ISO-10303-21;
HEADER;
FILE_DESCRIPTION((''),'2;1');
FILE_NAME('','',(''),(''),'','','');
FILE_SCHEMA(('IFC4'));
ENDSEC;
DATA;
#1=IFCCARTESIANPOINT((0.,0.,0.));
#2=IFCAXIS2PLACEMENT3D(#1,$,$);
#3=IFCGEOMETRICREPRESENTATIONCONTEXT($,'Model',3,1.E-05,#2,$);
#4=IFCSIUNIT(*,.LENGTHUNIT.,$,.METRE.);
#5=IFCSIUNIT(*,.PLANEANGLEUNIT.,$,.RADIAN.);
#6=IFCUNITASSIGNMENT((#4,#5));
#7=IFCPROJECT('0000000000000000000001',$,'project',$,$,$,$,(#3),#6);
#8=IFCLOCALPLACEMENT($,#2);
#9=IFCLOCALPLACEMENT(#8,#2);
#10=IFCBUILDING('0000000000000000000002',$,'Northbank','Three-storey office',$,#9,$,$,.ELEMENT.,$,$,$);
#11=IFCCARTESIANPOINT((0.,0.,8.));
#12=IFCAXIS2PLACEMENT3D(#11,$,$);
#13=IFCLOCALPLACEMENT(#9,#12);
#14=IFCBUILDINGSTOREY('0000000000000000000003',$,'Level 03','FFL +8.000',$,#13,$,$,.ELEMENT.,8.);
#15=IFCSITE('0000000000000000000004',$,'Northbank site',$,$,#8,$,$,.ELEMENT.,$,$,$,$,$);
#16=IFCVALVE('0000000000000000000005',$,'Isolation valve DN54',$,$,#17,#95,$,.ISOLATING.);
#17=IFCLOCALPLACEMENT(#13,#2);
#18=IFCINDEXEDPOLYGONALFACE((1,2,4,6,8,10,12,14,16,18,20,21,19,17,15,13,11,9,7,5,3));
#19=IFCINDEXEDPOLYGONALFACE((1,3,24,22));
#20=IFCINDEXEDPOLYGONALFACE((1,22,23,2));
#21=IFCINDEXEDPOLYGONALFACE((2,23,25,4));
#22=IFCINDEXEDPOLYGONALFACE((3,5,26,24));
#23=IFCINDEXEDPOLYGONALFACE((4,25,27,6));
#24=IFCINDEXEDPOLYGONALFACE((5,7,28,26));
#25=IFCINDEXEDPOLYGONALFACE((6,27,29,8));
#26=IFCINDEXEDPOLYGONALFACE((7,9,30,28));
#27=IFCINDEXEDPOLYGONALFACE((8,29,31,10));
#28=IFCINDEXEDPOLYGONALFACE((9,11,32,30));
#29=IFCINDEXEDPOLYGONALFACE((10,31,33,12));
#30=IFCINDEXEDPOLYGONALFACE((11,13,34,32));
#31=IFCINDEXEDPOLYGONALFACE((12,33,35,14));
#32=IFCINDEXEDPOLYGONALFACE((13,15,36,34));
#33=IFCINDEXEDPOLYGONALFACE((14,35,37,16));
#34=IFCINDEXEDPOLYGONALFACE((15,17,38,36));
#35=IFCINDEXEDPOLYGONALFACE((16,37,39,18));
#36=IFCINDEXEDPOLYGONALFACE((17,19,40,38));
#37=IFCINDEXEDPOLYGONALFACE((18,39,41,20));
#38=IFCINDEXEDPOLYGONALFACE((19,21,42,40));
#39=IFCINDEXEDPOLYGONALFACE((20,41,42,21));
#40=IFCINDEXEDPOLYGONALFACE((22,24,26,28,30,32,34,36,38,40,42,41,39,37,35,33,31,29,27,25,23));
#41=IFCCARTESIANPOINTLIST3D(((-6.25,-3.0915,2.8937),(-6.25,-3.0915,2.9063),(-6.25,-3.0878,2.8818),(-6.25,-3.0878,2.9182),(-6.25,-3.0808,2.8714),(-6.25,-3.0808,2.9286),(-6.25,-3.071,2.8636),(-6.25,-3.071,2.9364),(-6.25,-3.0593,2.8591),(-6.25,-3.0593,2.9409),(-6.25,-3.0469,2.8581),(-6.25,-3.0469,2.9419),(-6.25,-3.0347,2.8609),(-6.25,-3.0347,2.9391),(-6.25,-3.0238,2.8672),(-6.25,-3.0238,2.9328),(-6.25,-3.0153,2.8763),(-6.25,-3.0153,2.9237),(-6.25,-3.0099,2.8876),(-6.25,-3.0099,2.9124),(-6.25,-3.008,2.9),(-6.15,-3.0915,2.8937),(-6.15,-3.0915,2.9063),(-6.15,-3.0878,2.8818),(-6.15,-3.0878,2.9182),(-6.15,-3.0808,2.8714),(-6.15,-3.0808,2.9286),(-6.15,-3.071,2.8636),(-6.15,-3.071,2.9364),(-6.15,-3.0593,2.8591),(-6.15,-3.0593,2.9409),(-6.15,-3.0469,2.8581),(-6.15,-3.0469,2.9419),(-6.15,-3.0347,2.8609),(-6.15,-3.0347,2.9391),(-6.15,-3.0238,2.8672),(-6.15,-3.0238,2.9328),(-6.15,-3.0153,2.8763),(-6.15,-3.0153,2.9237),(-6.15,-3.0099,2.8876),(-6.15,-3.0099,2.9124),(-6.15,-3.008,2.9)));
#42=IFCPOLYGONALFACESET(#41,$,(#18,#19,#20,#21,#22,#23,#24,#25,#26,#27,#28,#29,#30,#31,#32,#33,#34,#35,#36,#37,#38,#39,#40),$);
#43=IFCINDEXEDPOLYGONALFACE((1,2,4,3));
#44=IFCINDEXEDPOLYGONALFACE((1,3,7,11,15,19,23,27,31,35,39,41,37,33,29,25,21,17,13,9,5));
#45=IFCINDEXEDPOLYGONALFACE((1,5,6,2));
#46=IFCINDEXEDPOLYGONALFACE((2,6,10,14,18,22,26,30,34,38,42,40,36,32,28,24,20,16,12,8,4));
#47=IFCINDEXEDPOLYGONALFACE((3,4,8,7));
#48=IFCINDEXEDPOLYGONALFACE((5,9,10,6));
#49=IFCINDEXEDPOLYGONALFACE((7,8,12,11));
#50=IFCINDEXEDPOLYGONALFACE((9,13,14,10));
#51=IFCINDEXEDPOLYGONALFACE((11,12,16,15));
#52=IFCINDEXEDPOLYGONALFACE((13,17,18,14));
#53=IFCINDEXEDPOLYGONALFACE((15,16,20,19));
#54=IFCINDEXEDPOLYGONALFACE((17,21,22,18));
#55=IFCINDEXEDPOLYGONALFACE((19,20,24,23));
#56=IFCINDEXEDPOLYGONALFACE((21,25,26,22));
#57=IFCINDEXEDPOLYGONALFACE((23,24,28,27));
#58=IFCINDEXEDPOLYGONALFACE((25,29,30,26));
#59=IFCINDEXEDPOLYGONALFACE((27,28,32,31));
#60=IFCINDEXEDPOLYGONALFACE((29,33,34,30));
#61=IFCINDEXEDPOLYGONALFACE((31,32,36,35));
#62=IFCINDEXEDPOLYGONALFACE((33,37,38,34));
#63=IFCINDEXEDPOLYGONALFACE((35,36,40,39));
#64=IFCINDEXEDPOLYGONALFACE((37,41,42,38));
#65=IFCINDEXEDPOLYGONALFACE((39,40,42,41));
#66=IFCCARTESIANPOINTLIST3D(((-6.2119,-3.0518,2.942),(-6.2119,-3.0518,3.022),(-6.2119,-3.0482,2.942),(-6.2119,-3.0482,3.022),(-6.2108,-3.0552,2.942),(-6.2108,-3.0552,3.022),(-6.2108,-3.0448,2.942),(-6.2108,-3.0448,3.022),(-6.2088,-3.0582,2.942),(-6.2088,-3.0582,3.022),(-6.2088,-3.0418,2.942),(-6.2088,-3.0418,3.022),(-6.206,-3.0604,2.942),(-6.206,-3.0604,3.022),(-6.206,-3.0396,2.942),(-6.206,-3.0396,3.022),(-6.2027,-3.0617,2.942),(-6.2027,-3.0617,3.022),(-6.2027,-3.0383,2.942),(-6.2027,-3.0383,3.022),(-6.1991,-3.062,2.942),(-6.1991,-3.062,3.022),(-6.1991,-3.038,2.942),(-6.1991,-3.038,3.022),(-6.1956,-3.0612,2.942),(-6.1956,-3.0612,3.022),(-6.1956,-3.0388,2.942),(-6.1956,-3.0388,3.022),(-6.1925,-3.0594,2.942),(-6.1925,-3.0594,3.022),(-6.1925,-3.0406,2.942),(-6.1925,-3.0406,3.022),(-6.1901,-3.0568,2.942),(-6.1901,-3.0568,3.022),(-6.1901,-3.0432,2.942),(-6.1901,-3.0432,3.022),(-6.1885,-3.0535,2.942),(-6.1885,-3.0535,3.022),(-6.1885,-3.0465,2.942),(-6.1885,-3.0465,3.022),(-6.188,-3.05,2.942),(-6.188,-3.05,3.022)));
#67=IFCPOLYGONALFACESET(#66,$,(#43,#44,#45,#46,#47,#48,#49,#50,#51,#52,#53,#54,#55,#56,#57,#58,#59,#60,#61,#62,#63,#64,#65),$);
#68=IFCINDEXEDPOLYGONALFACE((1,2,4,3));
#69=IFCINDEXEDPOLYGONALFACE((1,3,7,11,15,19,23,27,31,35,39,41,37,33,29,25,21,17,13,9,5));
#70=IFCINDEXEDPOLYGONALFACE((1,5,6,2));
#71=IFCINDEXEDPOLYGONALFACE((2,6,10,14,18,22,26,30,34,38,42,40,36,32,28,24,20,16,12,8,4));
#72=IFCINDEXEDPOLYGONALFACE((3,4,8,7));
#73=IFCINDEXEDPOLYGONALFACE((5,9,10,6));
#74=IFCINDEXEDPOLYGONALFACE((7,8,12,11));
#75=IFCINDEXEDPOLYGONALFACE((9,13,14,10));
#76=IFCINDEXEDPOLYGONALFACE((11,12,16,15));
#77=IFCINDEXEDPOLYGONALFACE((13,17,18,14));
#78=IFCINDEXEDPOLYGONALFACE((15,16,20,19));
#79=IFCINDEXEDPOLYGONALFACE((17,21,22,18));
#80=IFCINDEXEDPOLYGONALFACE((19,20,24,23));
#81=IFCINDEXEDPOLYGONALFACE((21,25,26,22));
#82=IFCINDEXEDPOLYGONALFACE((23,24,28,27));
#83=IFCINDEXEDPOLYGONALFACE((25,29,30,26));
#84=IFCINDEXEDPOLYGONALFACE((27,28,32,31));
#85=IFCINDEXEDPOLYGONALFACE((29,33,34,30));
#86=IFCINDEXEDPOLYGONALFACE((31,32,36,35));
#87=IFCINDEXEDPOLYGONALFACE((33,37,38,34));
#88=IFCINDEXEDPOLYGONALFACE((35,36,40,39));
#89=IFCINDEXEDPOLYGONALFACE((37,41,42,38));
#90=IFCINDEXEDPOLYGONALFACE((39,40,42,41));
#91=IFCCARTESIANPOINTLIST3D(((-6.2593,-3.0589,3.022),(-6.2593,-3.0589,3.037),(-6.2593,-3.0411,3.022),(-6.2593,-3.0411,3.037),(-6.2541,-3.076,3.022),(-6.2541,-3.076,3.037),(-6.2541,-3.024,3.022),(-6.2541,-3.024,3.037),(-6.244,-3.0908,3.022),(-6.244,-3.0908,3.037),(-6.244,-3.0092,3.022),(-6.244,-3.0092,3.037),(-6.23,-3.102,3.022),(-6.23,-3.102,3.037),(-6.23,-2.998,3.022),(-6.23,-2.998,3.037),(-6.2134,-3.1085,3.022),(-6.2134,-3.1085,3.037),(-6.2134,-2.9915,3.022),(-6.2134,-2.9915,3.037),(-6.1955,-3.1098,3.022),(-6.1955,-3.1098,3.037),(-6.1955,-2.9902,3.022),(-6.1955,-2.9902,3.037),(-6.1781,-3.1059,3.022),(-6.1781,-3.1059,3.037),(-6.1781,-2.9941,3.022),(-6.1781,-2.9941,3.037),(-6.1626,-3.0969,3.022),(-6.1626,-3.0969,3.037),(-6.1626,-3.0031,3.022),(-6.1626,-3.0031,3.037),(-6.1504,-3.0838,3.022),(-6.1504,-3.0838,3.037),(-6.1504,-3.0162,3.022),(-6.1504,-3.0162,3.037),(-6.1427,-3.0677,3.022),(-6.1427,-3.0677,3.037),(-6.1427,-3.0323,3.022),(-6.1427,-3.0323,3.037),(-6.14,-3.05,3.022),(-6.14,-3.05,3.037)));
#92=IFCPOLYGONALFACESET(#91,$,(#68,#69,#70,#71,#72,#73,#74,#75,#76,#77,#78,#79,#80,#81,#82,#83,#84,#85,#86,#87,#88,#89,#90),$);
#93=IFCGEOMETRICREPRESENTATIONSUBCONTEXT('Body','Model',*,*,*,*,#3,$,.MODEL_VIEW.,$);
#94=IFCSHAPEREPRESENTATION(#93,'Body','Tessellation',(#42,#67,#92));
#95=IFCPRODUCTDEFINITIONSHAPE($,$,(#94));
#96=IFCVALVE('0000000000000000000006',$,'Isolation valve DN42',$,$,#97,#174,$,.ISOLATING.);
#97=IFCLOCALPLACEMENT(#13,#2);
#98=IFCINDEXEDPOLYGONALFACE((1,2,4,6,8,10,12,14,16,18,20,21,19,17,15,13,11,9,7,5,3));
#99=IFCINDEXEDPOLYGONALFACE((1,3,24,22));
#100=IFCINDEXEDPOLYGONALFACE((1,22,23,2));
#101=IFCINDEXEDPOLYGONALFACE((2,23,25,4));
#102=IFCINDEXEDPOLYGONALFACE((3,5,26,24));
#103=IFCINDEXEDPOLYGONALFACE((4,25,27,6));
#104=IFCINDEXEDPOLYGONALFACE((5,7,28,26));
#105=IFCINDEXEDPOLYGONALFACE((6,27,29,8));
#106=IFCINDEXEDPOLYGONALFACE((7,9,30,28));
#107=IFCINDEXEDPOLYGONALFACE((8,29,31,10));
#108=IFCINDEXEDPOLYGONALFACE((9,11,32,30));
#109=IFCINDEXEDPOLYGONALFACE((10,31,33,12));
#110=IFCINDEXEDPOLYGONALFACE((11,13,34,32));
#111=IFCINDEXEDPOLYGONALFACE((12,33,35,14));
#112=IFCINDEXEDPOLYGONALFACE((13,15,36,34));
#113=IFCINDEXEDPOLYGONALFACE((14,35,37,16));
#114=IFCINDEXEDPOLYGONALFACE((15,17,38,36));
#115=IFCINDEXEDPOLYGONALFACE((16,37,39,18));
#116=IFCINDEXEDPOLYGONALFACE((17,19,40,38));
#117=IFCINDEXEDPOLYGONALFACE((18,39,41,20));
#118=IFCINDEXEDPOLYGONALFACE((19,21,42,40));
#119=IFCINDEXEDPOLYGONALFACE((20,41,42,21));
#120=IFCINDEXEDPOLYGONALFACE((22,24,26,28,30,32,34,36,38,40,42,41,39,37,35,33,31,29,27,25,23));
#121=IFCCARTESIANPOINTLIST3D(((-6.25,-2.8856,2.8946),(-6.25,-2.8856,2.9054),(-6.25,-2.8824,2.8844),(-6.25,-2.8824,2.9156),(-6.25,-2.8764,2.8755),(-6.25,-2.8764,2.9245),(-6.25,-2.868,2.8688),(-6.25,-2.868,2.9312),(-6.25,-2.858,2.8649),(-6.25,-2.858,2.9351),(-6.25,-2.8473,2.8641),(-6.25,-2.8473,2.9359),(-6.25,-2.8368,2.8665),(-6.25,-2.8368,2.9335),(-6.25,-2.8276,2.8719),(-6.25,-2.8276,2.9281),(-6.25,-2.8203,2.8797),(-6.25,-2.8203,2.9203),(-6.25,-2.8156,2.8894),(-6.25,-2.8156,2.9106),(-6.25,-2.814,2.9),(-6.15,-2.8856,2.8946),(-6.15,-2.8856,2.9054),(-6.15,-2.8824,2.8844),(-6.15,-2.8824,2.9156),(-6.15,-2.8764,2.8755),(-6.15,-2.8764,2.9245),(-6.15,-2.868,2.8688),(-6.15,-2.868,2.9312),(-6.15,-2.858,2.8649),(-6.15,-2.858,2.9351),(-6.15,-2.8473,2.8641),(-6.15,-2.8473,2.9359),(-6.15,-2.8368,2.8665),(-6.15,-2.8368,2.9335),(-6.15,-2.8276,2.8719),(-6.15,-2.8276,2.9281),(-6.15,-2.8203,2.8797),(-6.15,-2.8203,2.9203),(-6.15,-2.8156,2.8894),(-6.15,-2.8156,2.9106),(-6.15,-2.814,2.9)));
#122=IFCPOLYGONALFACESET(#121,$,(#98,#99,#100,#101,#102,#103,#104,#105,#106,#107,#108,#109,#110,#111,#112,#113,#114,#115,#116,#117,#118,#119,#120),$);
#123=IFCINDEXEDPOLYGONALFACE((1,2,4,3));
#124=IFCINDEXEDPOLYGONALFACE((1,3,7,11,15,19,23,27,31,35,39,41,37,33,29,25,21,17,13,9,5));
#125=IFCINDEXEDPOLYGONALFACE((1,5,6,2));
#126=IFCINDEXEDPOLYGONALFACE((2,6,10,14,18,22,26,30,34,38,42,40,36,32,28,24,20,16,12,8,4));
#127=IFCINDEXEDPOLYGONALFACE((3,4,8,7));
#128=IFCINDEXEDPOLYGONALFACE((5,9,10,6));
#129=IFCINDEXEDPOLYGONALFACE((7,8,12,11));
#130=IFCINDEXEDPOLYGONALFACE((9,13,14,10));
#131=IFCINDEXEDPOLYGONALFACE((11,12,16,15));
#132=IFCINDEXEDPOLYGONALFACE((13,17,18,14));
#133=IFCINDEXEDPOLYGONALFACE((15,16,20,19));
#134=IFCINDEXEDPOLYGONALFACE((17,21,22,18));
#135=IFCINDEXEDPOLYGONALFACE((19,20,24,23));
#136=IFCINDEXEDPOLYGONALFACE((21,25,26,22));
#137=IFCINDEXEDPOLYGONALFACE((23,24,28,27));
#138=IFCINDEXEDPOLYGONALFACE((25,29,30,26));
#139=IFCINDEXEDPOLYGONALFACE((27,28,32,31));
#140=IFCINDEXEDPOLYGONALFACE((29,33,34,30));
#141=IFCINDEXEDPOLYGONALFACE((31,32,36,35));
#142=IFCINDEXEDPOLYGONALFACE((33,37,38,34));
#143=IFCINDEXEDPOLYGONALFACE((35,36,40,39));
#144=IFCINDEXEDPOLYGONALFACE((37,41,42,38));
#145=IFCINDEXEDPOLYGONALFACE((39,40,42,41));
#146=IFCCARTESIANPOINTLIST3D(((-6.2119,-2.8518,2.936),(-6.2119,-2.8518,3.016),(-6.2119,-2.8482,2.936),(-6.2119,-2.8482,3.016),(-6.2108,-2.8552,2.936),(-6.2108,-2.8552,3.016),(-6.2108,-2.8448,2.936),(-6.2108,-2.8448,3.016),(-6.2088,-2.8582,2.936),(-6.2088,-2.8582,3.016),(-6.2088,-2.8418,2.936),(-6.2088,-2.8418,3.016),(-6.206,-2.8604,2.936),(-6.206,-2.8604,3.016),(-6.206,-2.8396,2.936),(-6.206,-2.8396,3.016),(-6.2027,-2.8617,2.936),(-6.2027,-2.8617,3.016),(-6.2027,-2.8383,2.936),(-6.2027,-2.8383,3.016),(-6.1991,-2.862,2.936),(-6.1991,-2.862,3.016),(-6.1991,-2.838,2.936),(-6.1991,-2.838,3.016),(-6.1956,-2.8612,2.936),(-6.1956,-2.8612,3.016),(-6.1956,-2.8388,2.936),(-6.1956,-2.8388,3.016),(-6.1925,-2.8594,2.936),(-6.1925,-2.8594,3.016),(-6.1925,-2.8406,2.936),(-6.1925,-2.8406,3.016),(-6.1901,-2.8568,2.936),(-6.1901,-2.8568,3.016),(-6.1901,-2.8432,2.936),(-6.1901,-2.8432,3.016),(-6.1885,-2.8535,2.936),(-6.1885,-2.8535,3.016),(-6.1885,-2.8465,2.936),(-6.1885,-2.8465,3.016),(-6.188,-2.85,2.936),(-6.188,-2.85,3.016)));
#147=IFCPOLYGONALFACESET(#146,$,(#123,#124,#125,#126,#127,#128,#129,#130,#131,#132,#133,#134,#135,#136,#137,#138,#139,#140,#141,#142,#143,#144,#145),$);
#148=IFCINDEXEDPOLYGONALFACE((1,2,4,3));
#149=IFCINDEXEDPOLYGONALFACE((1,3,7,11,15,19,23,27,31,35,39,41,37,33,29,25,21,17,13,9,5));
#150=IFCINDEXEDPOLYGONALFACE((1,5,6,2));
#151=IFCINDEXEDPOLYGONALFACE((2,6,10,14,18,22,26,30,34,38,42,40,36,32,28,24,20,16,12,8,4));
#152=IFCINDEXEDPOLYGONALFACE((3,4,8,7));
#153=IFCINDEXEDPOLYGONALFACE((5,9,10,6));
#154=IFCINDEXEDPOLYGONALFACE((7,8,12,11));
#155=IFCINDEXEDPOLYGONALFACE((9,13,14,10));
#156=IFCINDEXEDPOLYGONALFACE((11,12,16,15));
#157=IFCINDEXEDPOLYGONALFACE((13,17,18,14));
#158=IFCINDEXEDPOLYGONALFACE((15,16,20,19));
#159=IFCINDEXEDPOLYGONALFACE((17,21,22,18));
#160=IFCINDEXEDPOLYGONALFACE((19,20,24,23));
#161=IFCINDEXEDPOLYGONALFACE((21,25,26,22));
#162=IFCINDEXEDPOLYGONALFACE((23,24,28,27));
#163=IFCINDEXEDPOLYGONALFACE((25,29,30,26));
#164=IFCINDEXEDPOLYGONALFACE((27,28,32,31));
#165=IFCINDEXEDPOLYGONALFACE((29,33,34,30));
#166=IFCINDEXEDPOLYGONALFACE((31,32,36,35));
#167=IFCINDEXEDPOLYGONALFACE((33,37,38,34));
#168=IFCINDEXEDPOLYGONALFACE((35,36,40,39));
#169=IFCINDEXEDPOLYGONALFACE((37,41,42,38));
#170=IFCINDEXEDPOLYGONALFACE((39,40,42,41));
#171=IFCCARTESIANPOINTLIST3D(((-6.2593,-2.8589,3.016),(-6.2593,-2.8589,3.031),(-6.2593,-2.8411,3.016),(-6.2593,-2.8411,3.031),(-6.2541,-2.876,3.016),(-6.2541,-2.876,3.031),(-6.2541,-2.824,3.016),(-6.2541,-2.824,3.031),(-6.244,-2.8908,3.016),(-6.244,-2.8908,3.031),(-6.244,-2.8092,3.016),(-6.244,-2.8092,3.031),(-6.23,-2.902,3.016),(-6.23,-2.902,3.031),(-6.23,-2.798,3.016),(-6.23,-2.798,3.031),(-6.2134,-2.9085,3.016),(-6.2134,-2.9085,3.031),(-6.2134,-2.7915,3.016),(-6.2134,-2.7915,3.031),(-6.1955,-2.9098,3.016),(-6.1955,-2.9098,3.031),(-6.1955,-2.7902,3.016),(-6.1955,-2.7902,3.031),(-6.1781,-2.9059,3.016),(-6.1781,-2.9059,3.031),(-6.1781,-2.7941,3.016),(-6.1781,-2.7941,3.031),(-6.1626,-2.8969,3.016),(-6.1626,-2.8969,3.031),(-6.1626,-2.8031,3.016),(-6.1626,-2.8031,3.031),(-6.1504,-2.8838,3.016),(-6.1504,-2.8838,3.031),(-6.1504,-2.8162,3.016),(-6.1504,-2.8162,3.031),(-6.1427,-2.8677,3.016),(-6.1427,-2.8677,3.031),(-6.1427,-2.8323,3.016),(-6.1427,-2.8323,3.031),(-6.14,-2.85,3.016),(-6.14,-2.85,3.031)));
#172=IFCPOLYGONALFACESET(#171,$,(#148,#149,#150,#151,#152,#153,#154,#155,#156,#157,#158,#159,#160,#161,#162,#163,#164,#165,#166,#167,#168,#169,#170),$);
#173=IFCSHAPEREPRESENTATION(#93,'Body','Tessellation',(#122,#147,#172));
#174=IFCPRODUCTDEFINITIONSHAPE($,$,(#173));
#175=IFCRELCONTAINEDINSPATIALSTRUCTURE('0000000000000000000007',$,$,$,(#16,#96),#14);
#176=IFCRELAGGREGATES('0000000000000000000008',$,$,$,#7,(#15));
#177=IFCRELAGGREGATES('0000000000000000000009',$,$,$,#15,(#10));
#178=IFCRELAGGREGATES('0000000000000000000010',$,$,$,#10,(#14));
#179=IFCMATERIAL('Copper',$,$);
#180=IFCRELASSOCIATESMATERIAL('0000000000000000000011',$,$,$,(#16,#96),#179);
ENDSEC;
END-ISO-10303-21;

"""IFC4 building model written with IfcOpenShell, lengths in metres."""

from ifc_helpers import new_model, si_unit, frame, origin, place, context, subcontext, project, spatial, circle, extrude, material, element, save


model = new_model("IFC4")

# Units and contexts
model_context = context("Model", 3, precision=1e-05, world=origin())
body_context = subcontext(model_context, "Body", "Model", "MODEL_VIEW")
ifc_project = project(units=[si_unit("LENGTHUNIT", "METRE"), si_unit("PLANEANGLEUNIT", "RADIAN")], contexts=[model_context])

# Site, building, storey
site_placement = place(None, origin())
site = spatial("IfcSite", under=ifc_project, at=site_placement, Name="Northbank site", CompositionType="ELEMENT")
building_placement = place(site_placement, origin())
building = spatial("IfcBuilding", under=site, at=building_placement, Name="Northbank", Description="Three-storey office", CompositionType="ELEMENT")
storey_placement = place(building_placement, frame((0.0, 0.0, 8.0)))
storey = spatial("IfcBuildingStorey", under=building, at=storey_placement, Name="Level 03", Description="FFL +8.000", CompositionType="ELEMENT", Elevation=8.0)

# Shared definitions
ifc_material_1 = material(Name="Copper")

# Valve
valve_1_placement = place(storey_placement, frame((0.0, 0.0, -8.0)))
element("IfcValve", 1, at=valve_1_placement, inside=storey, material=ifc_material_1, Name="Isolation valve DN54", PredefinedType="ISOLATING", context=body_context, shape_type="SweptSolid", body=[
    extrude(circle(Radius=0.042), frame((-6.25, -3.05, 10.9), z_axis=(1.0, 0.0, 0.0), x_axis=(0.0, 1.0, 0.0)), (0.0, 0.0, 1.0), 0.1),
    extrude(circle(Radius=0.012), frame((-6.2, -3.05, 10.942), z_axis=(0.0, 0.0, 1.0), x_axis=(1.0, 0.0, 0.0)), (0.0, 0.0, 1.0), 0.08),
    extrude(circle(Radius=0.06), frame((-6.2, -3.05, 11.022), z_axis=(0.0, 0.0, 1.0), x_axis=(1.0, 0.0, 0.0)), (0.0, 0.0, 1.0), 0.015),
])

# Valve
valve_2_placement = place(storey_placement, frame((0.0, 0.0, -8.0)))
element("IfcValve", 2, at=valve_2_placement, inside=storey, material=ifc_material_1, Name="Isolation valve DN42", PredefinedType="ISOLATING", context=body_context, shape_type="SweptSolid", body=[
    extrude(circle(Radius=0.036), frame((-6.25, -2.85, 10.9), z_axis=(1.0, 0.0, 0.0), x_axis=(0.0, 1.0, 0.0)), (0.0, 0.0, 1.0), 0.1),
    extrude(circle(Radius=0.012), frame((-6.2, -2.85, 10.936), z_axis=(0.0, 0.0, 1.0), x_axis=(1.0, 0.0, 0.0)), (0.0, 0.0, 1.0), 0.08),
    extrude(circle(Radius=0.06), frame((-6.2, -2.85, 11.016), z_axis=(0.0, 0.0, 1.0), x_axis=(1.0, 0.0, 0.0)), (0.0, 0.0, 1.0), 0.015),
])

save(model, "model.ifc")
